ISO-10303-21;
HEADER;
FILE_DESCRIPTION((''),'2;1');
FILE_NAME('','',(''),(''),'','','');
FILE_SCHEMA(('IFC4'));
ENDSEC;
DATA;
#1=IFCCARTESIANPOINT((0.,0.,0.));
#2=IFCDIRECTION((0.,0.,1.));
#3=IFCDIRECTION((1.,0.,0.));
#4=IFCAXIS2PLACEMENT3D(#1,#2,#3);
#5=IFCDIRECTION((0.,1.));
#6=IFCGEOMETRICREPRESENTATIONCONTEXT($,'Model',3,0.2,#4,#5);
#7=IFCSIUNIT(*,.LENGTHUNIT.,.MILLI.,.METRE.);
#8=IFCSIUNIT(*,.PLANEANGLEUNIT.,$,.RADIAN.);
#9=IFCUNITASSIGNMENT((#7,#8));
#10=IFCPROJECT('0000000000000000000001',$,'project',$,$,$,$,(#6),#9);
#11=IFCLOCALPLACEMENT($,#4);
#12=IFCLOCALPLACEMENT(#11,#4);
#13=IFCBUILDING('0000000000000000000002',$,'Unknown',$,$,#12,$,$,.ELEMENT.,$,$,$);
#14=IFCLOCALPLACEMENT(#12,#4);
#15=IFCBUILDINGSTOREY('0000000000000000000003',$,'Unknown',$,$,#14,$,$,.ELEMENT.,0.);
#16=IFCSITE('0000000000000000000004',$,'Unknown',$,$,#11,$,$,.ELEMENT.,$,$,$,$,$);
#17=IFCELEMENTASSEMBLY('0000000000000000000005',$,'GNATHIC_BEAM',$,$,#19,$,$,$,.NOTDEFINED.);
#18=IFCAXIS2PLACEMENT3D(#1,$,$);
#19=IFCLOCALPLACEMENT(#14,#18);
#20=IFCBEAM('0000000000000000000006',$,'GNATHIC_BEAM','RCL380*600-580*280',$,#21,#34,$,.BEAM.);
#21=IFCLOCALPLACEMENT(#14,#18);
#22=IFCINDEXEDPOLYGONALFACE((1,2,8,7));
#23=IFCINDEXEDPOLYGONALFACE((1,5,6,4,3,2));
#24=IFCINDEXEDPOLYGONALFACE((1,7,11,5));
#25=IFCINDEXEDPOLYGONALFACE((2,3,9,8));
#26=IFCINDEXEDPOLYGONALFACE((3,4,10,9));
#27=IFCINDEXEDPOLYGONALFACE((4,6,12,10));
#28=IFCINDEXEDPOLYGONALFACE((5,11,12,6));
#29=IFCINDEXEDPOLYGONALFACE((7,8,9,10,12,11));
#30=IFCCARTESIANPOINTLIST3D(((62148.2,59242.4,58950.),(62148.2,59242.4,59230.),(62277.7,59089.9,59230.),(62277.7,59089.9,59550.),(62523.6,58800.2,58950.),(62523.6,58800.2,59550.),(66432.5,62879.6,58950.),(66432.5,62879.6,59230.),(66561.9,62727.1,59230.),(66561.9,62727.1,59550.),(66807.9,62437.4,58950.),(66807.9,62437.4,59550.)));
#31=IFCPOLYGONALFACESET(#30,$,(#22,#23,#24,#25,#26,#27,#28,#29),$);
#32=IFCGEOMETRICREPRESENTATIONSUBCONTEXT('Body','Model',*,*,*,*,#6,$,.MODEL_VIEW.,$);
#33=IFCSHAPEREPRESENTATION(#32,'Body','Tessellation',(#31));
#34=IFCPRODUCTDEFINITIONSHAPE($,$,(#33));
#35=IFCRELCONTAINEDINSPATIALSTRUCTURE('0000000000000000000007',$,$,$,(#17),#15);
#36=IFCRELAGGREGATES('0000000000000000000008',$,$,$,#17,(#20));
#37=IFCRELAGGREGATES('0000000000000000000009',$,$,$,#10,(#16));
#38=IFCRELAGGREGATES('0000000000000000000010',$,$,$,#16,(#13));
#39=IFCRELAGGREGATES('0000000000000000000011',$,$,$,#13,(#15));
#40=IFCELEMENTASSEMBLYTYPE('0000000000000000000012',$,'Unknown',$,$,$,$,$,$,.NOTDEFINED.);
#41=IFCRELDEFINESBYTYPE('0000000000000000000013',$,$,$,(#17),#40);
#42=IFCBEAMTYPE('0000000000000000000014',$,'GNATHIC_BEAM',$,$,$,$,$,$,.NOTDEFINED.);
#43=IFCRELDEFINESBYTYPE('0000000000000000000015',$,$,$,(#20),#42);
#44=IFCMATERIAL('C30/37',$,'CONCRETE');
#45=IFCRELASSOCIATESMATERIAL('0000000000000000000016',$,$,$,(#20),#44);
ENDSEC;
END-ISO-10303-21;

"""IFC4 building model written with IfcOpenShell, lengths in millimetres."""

from ifc_helpers import new_model, si_unit, direction, frame, origin_with_axes, place, context, subcontext, project, spatial, polyline, outline, extrude, material, material_profile, profile_set, profile_usage, type_object, element, aggregate, save


model = new_model("IFC4")

# Units and contexts
model_context = context("Model", 3, precision=0.2, world=origin_with_axes(), true_north=direction((0.0, 1.0)))
body_context = subcontext(model_context, "Body", "Model", "MODEL_VIEW")
ifc_project = project(units=[si_unit("LENGTHUNIT", "METRE", prefix="MILLI"), si_unit("PLANEANGLEUNIT", "RADIAN")], contexts=[model_context])

# Site, building, storey
site_placement = place(None, origin_with_axes())
site = spatial("IfcSite", under=ifc_project, at=site_placement, Name="Unknown", CompositionType="ELEMENT")
building_placement = place(site_placement, origin_with_axes())
building = spatial("IfcBuilding", under=site, at=building_placement, Name="Unknown", CompositionType="ELEMENT")
storey_placement = place(building_placement, origin_with_axes())
storey = spatial("IfcBuildingStorey", under=building, at=storey_placement, Name="Unknown", CompositionType="ELEMENT", Elevation=0.0)

# Shared definitions
element_assembly_type = type_object("IfcElementAssemblyType", Name="Unknown", PredefinedType="NOTDEFINED")

# Element assembly, beam
ifc_material_1 = material(Name="C30/37", Category="CONCRETE")
ifc_material_profile_1 = material_profile(ifc_material_1, outline(polyline([(-190.0, -300.0), (390.0, -300.0), (390.0, -20.0), (190.0, -20.0), (190.0, 300.0), (-190.0, 300.0), (-190.0, -300.0)])), Name="RCL380*600-580*280")
ifc_profile_set_1 = profile_set([ifc_material_profile_1])
ifc_profile_usage_1 = profile_usage(ifc_profile_set_1, cardinal=2)
beam_type_1 = type_object("IfcBeamType", Name="GNATHIC_BEAM")
assembly_1_placement = place(storey_placement, frame((66684.9, 62582.3, 59250.0), z_axis=(-0.64719, 0.762329, 0.0), x_axis=(-0.762329, -0.64719, 0.0)))
assembly_1 = element("IfcElementAssembly", 1, at=assembly_1_placement, inside=storey, type_object=element_assembly_type, Name="GNATHIC_BEAM", PredefinedType="NOTDEFINED")
beam_1_placement = place(assembly_1_placement, origin_with_axes())
beam_1 = element("IfcBeam", 2, at=beam_1_placement, type_object=beam_type_1, material=ifc_profile_usage_1, Name="GNATHIC_BEAM", Description="RCL380*600-580*280", PredefinedType="BEAM", context=body_context, shape_type="SolidModel", body=[
    extrude(outline(polyline([(-190.0, -300.0), (390.0, -300.0), (390.0, -20.0), (190.0, -20.0), (190.0, 300.0), (-190.0, 300.0), (-190.0, -300.0)])), frame((0.0, 0.0, 0.0), z_axis=(-1.0, 0.0, 0.0), x_axis=(0.0, 0.0, 1.0)), (0.0, 0.0, -1.0), 5620.0),
])
aggregate(assembly_1, [beam_1])

save(model, "model.ifc")
